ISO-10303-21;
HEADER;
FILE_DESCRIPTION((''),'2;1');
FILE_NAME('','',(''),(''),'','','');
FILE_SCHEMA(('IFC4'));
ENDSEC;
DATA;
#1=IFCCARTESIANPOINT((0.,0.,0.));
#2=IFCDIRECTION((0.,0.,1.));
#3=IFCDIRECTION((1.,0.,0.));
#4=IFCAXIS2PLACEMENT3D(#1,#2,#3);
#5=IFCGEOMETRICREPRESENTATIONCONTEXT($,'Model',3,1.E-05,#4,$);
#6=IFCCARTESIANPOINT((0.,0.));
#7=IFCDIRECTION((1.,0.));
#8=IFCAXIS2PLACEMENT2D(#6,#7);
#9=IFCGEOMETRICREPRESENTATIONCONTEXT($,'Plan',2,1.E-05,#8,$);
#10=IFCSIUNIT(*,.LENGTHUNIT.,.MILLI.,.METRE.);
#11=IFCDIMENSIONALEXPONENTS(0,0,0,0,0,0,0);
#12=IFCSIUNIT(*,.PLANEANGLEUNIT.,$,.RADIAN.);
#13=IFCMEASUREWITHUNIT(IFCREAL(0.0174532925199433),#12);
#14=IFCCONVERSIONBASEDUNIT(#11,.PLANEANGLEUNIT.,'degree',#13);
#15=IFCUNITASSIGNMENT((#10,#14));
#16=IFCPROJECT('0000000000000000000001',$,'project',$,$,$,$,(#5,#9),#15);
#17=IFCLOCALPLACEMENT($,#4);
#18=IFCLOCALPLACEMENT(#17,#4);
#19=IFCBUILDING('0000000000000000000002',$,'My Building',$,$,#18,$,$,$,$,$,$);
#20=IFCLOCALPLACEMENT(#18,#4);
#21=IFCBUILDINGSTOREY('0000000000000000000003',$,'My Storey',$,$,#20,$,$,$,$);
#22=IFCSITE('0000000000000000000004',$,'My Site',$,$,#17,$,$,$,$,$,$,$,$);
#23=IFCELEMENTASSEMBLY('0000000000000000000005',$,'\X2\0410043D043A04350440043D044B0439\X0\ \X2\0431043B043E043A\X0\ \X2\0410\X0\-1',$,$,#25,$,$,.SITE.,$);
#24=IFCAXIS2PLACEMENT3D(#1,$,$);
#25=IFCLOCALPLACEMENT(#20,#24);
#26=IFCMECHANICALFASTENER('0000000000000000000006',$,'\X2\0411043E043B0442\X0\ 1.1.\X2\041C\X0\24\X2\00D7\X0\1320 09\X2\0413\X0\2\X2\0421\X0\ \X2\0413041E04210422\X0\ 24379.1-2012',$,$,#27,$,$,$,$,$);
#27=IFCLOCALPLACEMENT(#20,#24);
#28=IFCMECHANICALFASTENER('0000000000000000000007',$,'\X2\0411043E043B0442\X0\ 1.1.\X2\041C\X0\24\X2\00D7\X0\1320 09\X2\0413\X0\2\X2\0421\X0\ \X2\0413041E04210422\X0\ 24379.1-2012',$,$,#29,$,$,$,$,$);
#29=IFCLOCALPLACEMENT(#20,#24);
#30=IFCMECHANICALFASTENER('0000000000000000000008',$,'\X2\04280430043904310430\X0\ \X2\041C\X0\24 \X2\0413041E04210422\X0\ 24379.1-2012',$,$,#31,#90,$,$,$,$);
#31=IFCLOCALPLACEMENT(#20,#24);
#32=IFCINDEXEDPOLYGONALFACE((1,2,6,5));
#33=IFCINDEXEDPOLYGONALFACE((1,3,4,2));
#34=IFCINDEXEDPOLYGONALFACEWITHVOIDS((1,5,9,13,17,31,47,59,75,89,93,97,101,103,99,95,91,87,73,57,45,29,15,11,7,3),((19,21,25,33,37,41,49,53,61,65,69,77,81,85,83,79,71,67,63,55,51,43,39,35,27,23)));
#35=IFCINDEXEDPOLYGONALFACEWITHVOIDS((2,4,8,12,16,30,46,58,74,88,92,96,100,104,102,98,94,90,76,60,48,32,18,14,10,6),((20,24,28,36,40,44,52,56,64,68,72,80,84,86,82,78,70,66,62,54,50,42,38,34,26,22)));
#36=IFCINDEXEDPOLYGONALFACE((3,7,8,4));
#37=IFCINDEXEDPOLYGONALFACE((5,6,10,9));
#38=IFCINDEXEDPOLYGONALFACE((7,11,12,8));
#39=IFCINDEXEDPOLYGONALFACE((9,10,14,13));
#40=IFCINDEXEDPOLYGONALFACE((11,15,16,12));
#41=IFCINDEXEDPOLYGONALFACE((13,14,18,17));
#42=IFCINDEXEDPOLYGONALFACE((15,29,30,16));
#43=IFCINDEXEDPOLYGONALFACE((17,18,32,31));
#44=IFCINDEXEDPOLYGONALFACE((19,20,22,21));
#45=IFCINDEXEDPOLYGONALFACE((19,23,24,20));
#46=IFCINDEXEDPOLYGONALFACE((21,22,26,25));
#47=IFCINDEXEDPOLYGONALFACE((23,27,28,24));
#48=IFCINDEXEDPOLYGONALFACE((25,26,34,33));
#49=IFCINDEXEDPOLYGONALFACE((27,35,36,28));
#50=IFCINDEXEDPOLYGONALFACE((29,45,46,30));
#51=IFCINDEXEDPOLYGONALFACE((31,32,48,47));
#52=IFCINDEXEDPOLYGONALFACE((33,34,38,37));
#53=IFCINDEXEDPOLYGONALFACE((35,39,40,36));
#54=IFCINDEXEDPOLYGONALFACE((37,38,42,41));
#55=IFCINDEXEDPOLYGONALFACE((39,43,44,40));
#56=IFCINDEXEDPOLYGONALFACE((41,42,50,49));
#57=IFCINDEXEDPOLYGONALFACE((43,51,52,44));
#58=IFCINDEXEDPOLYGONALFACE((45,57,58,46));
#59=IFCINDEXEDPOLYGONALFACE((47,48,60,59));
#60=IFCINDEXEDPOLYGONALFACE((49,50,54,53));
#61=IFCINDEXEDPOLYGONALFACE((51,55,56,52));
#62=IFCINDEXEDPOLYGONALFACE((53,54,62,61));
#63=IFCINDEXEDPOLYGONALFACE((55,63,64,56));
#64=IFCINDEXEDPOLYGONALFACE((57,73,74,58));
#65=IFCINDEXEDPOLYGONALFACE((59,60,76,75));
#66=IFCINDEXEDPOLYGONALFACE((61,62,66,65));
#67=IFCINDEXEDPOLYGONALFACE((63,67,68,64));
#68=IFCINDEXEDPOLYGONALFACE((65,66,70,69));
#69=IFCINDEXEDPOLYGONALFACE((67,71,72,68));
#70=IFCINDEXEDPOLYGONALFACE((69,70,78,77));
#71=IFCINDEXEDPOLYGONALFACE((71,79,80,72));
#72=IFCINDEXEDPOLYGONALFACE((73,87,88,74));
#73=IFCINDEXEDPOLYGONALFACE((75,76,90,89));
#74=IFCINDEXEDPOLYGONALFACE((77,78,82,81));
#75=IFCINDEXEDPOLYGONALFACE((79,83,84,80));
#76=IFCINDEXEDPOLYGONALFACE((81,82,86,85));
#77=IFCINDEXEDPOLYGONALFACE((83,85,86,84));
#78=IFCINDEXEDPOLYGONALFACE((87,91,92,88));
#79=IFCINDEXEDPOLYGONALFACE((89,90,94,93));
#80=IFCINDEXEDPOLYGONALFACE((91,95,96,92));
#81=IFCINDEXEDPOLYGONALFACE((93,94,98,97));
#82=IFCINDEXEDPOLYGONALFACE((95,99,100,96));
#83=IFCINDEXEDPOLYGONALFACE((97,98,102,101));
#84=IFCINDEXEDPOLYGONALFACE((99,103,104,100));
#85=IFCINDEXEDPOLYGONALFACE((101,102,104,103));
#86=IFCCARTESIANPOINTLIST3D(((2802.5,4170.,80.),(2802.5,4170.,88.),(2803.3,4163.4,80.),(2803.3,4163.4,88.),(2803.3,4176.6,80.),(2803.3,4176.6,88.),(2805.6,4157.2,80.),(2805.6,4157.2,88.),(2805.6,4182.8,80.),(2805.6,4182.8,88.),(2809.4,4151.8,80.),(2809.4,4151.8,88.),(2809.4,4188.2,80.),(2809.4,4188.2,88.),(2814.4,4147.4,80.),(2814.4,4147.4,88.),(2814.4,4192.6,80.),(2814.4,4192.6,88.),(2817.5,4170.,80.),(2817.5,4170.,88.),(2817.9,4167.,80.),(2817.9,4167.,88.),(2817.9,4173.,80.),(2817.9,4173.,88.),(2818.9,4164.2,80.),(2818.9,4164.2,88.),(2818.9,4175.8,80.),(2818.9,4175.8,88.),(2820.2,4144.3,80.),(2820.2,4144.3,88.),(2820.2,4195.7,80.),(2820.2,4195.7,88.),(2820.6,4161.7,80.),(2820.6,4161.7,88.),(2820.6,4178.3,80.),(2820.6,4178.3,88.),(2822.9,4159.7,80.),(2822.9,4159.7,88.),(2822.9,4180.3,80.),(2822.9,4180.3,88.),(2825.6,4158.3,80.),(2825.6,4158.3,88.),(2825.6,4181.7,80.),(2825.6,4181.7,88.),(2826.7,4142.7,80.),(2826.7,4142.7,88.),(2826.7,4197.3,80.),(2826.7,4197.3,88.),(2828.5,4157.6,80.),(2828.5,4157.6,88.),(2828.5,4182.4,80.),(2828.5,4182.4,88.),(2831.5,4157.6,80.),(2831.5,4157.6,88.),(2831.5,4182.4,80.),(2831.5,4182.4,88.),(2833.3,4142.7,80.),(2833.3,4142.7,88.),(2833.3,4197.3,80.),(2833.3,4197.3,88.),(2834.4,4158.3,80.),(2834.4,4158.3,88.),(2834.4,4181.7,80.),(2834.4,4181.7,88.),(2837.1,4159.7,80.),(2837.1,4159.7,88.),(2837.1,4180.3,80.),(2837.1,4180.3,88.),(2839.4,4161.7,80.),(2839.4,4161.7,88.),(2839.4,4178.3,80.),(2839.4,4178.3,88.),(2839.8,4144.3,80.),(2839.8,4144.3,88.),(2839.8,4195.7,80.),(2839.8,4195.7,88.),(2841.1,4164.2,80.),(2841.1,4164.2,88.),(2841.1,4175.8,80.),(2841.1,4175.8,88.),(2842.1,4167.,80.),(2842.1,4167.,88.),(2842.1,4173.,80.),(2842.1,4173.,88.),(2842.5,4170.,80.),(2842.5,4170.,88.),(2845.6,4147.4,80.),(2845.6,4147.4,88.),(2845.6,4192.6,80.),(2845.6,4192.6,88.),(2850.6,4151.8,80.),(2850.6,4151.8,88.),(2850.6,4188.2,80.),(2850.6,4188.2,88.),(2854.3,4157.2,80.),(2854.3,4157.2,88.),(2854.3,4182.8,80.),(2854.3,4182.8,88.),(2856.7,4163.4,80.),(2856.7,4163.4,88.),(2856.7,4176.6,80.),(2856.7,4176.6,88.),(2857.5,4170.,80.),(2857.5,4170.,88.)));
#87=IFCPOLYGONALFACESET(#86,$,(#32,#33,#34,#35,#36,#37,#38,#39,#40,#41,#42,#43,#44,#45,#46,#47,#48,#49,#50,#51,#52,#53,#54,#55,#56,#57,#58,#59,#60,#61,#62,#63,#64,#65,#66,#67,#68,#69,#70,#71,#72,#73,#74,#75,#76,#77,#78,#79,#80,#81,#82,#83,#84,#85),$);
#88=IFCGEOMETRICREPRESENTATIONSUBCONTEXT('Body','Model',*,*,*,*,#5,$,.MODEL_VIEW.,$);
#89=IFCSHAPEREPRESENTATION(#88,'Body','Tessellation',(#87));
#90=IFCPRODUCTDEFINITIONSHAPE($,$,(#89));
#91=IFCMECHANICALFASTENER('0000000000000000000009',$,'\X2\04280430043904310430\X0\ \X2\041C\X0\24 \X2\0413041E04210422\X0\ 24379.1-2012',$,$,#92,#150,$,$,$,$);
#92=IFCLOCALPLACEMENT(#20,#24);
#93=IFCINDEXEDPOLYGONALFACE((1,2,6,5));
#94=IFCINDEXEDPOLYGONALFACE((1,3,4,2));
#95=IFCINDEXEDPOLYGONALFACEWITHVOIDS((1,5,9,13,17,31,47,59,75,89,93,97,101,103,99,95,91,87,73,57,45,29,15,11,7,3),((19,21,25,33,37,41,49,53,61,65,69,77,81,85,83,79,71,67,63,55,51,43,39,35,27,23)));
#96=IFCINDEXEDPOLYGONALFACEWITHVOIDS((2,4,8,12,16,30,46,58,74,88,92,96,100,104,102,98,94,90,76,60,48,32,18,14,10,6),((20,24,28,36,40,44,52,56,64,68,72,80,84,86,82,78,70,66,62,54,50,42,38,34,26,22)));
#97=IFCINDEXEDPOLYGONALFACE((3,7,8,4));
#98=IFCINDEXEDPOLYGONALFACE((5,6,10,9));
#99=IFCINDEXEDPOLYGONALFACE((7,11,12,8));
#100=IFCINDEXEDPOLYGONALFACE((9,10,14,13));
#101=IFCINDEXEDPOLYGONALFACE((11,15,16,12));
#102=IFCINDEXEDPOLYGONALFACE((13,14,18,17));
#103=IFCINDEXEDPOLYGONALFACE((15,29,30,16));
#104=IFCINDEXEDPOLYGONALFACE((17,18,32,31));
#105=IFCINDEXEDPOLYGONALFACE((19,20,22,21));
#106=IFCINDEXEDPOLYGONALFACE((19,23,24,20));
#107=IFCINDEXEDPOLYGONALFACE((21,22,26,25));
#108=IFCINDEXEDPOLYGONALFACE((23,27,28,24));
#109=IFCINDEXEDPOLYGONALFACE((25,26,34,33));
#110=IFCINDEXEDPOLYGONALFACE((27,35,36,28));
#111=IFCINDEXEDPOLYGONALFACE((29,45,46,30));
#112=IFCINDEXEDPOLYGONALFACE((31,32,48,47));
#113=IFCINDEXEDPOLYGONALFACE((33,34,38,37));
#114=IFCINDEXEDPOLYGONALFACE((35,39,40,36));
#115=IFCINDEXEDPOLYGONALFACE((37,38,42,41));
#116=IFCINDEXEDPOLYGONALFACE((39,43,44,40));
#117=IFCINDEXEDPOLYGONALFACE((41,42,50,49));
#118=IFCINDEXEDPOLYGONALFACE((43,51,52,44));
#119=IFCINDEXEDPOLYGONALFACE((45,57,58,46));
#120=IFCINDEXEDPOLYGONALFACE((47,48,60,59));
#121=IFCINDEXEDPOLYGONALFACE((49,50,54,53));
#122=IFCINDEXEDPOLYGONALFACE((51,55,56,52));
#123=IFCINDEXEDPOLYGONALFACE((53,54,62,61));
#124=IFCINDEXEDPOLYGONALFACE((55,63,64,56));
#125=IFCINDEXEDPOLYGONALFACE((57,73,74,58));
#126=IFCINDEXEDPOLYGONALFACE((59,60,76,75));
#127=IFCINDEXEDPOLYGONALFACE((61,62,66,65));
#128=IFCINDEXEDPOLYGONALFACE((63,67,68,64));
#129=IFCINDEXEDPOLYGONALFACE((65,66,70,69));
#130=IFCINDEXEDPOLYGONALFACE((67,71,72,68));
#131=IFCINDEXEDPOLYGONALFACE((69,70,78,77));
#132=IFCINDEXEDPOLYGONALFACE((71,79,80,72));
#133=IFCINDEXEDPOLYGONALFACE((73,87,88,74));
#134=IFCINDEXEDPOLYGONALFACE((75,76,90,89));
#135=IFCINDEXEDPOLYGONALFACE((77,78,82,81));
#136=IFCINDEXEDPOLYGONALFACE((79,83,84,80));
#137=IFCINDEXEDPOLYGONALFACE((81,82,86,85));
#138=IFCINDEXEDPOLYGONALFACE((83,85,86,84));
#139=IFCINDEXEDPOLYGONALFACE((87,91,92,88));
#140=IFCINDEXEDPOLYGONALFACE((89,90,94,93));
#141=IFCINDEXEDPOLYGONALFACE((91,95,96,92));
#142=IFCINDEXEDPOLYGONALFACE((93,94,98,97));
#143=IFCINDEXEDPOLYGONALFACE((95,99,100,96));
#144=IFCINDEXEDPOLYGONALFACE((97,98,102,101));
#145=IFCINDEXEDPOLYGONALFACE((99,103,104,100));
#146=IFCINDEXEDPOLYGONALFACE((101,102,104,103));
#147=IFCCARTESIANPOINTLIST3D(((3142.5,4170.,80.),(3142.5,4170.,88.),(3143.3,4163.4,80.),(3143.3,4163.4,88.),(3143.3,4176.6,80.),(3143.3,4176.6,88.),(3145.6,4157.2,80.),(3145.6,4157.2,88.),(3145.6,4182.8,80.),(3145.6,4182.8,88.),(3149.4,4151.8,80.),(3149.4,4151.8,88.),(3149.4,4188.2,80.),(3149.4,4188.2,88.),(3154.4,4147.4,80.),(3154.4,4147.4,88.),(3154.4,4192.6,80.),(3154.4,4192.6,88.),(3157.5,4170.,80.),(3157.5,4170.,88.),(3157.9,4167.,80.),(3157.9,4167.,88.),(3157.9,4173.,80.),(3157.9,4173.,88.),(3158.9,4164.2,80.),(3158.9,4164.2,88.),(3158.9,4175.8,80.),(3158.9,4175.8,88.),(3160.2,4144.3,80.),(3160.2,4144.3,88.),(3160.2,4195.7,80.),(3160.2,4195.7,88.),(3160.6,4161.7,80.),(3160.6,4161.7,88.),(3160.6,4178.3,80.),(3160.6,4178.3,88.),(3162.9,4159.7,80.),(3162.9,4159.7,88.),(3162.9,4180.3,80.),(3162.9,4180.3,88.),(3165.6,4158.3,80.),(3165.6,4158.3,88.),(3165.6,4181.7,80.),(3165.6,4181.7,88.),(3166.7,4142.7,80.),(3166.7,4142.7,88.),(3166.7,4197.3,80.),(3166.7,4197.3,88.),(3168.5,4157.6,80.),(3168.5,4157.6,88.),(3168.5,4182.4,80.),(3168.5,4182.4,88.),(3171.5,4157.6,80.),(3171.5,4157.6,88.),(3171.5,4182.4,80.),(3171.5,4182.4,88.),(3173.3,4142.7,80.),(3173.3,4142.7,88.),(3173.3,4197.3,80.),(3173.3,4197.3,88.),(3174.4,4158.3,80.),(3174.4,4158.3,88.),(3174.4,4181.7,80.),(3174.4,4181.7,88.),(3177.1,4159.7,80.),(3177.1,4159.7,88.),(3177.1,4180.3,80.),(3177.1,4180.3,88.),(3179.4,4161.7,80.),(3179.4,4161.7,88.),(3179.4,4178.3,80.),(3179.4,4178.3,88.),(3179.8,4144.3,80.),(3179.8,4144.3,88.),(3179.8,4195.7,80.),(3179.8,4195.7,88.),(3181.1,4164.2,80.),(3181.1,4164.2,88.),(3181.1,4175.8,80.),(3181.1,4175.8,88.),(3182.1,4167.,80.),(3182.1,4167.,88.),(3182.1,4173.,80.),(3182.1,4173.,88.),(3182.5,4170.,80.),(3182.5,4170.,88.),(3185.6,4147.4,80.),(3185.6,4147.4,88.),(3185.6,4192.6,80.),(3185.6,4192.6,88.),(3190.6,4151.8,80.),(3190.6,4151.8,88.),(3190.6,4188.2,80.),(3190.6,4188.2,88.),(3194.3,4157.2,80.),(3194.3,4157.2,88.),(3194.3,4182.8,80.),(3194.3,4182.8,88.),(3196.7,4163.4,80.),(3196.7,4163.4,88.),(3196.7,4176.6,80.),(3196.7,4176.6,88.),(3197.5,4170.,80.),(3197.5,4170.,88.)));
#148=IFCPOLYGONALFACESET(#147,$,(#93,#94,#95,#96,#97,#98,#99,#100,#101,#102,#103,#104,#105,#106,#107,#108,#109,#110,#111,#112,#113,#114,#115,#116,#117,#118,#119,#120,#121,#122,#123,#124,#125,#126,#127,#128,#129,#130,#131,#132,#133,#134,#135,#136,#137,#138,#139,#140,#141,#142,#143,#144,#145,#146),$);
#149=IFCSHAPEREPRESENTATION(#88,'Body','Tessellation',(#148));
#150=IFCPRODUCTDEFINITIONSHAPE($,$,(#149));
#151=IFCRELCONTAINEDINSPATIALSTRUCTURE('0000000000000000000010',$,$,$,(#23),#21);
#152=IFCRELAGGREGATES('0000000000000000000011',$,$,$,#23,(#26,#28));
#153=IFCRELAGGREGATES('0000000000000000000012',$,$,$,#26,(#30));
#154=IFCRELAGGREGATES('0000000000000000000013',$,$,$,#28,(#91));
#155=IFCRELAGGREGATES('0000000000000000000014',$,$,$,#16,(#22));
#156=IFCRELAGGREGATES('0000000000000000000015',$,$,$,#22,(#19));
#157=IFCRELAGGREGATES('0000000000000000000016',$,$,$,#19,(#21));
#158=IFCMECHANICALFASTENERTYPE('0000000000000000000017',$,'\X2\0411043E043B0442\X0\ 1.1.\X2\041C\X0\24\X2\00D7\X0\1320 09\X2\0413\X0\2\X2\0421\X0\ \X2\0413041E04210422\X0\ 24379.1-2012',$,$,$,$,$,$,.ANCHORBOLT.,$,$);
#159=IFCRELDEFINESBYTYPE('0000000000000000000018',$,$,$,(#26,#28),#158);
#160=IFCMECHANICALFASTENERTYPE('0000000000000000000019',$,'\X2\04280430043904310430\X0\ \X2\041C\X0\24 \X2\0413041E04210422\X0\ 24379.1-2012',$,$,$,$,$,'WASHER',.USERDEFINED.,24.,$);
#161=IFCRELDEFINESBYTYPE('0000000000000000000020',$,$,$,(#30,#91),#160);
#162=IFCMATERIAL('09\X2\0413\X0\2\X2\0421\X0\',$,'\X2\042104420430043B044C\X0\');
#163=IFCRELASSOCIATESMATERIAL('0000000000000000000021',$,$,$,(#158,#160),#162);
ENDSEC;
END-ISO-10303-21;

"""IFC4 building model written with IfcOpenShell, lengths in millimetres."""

from ifc_helpers import new_model, entity, si_unit, converted_unit, frame, origin_with_axes, origin_2d_with_axis, place, context, subcontext, project, spatial, polyline, outline, extrude, source, transform, mapped, material, type_object, type_shapes, element, aggregate, save


model = new_model("IFC4")

# Units and contexts
model_context = context("Model", 3, precision=1e-05, world=origin_with_axes())
plan_context = context("Plan", 2, precision=1e-05, world=origin_2d_with_axis())
body_context = subcontext(model_context, "Body", "Model", "MODEL_VIEW")
ifc_project = project(units=[si_unit("LENGTHUNIT", "METRE", prefix="MILLI"), converted_unit("PLANEANGLEUNIT", "degree", entity("IfcReal", 0.0174532925199433), si_unit("PLANEANGLEUNIT", "RADIAN"), dimensions=[0, 0, 0, 0, 0, 0, 0])], contexts=[model_context, plan_context])

# Site, building, storey
site_placement = place(None, origin_with_axes())
site = spatial("IfcSite", under=ifc_project, at=site_placement, Name="My Site")
building_placement = place(site_placement, origin_with_axes())
building = spatial("IfcBuilding", under=site, at=building_placement, Name="My Building")
storey_placement = place(building_placement, origin_with_axes())
storey = spatial("IfcBuildingStorey", under=building, at=storey_placement, Name="My Storey")

# Element assembly, mechanical fasteners
ifc_material_1 = material(Name="09Г2С", Category="Сталь")
mechanical_fastener_type_1 = type_object("IfcMechanicalFastenerType", Name="Болт 1.1.М24×1320 09Г2С ГОСТ 24379.1-2012", PredefinedType="ANCHORBOLT", material=ifc_material_1)
assembly_1_placement = place(storey_placement, frame((3000.0, 4000.0, 0.0), z_axis=(0.0, 0.0, 1.0), x_axis=(1.0, 0.0, 0.0)))
assembly_1 = element("IfcElementAssembly", 1, at=assembly_1_placement, inside=storey, Name="Анкерный блок А-1", AssemblyPlace="SITE")
mechanical_fastener_1_placement = place(assembly_1_placement, frame((-170.0, 170.0, 0.0), z_axis=(0.0, 0.0, 1.0), x_axis=(-1.0, 0.0, 0.0)))
mechanical_fastener_1 = element("IfcMechanicalFastener", 2, at=mechanical_fastener_1_placement, type_object=mechanical_fastener_type_1, Name="Болт 1.1.М24×1320 09Г2С ГОСТ 24379.1-2012")
mechanical_fastener_2_placement = place(assembly_1_placement, frame((170.0, 170.0, 0.0), z_axis=(0.0, 0.0, 1.0), x_axis=(-1.0, 0.0, 0.0)))
mechanical_fastener_2 = element("IfcMechanicalFastener", 3, at=mechanical_fastener_2_placement, type_object=mechanical_fastener_type_1, Name="Болт 1.1.М24×1320 09Г2С ГОСТ 24379.1-2012")
aggregate(assembly_1, [mechanical_fastener_1, mechanical_fastener_2])

# Mechanical fasteners
mechanical_fastener_type_2 = type_object("IfcMechanicalFastenerType", Name="Шайба М24 ГОСТ 24379.1-2012", ElementType="WASHER", NominalDiameter=24.0, PredefinedType="USERDEFINED", material=ifc_material_1)
shared_shape_1 = source(origin_with_axes(), body_context, "Body", "SweptSolid", [
    extrude(outline(polyline([(27.5, 0.0), (26.7, 6.6), (24.4, 12.8), (20.6, 18.2), (15.6, 22.6), (9.8, 25.7), (3.3, 27.3), (-3.3, 27.3), (-9.8, 25.7), (-15.6, 22.6), (-20.6, 18.2), (-24.4, 12.8), (-26.7, 6.6), (-27.5, 0.0), (-26.7, -6.6), (-24.4, -12.8), (-20.6, -18.2), (-15.6, -22.6), (-9.8, -25.7), (-3.3, -27.3), (3.3, -27.3), (9.8, -25.7), (15.6, -22.6), (20.6, -18.2), (24.4, -12.8), (26.7, -6.6), (27.5, 0.0)]), holes=[polyline([(-4.4, -11.7), (-7.1, -10.3), (-9.4, -8.3), (-11.1, -5.8), (-12.1, -3.0), (-12.5, 0.0), (-12.1, 3.0), (-11.1, 5.8), (-9.4, 8.3), (-7.1, 10.3), (-4.4, 11.7), (-1.5, 12.4), (1.5, 12.4), (4.4, 11.7), (7.1, 10.3), (9.4, 8.3), (11.1, 5.8), (12.1, 3.0), (12.5, 0.0), (12.1, -3.0), (11.1, -5.8), (9.4, -8.3), (7.1, -10.3), (4.4, -11.7), (1.5, -12.4), (-1.5, -12.4), (-4.4, -11.7)])]), frame((0.0, 0.0, 0.0), z_axis=(0.0, 0.0, 1.0), x_axis=(0.120537, -0.992709, 0.0)), (0.0, 0.0, 1.0), 8.0),
])
type_shapes(mechanical_fastener_type_2, [shared_shape_1])
mechanical_fastener_3_placement = place(mechanical_fastener_1_placement, frame((0.0, 0.0, 80.0), z_axis=(0.0, 0.0, 1.0), x_axis=(1.0, 0.0, 0.0)))
mechanical_fastener_3 = element("IfcMechanicalFastener", 4, at=mechanical_fastener_3_placement, type_object=mechanical_fastener_type_2, Name="Шайба М24 ГОСТ 24379.1-2012", context=body_context, shape_type="MappedRepresentation", body=[
    mapped(shared_shape_1, transform((0.0, 0.0, 0.0), x_axis=(1.0, 0.0, 0.0), y_axis=(0.0, 1.0, 0.0), z_axis=(0.0, 0.0, 1.0), scale=1.0)),
])
aggregate(mechanical_fastener_1, [mechanical_fastener_3])
mechanical_fastener_4_placement = place(mechanical_fastener_2_placement, frame((0.0, 0.0, 80.0), z_axis=(0.0, 0.0, 1.0), x_axis=(1.0, 0.0, 0.0)))
mechanical_fastener_4 = element("IfcMechanicalFastener", 5, at=mechanical_fastener_4_placement, type_object=mechanical_fastener_type_2, Name="Шайба М24 ГОСТ 24379.1-2012", context=body_context, shape_type="MappedRepresentation", body=[
    mapped(shared_shape_1, transform((0.0, 0.0, 0.0), x_axis=(1.0, 0.0, 0.0), y_axis=(0.0, 1.0, 0.0), z_axis=(0.0, 0.0, 1.0), scale=1.0)),
])
aggregate(mechanical_fastener_2, [mechanical_fastener_4])

save(model, "model.ifc")
